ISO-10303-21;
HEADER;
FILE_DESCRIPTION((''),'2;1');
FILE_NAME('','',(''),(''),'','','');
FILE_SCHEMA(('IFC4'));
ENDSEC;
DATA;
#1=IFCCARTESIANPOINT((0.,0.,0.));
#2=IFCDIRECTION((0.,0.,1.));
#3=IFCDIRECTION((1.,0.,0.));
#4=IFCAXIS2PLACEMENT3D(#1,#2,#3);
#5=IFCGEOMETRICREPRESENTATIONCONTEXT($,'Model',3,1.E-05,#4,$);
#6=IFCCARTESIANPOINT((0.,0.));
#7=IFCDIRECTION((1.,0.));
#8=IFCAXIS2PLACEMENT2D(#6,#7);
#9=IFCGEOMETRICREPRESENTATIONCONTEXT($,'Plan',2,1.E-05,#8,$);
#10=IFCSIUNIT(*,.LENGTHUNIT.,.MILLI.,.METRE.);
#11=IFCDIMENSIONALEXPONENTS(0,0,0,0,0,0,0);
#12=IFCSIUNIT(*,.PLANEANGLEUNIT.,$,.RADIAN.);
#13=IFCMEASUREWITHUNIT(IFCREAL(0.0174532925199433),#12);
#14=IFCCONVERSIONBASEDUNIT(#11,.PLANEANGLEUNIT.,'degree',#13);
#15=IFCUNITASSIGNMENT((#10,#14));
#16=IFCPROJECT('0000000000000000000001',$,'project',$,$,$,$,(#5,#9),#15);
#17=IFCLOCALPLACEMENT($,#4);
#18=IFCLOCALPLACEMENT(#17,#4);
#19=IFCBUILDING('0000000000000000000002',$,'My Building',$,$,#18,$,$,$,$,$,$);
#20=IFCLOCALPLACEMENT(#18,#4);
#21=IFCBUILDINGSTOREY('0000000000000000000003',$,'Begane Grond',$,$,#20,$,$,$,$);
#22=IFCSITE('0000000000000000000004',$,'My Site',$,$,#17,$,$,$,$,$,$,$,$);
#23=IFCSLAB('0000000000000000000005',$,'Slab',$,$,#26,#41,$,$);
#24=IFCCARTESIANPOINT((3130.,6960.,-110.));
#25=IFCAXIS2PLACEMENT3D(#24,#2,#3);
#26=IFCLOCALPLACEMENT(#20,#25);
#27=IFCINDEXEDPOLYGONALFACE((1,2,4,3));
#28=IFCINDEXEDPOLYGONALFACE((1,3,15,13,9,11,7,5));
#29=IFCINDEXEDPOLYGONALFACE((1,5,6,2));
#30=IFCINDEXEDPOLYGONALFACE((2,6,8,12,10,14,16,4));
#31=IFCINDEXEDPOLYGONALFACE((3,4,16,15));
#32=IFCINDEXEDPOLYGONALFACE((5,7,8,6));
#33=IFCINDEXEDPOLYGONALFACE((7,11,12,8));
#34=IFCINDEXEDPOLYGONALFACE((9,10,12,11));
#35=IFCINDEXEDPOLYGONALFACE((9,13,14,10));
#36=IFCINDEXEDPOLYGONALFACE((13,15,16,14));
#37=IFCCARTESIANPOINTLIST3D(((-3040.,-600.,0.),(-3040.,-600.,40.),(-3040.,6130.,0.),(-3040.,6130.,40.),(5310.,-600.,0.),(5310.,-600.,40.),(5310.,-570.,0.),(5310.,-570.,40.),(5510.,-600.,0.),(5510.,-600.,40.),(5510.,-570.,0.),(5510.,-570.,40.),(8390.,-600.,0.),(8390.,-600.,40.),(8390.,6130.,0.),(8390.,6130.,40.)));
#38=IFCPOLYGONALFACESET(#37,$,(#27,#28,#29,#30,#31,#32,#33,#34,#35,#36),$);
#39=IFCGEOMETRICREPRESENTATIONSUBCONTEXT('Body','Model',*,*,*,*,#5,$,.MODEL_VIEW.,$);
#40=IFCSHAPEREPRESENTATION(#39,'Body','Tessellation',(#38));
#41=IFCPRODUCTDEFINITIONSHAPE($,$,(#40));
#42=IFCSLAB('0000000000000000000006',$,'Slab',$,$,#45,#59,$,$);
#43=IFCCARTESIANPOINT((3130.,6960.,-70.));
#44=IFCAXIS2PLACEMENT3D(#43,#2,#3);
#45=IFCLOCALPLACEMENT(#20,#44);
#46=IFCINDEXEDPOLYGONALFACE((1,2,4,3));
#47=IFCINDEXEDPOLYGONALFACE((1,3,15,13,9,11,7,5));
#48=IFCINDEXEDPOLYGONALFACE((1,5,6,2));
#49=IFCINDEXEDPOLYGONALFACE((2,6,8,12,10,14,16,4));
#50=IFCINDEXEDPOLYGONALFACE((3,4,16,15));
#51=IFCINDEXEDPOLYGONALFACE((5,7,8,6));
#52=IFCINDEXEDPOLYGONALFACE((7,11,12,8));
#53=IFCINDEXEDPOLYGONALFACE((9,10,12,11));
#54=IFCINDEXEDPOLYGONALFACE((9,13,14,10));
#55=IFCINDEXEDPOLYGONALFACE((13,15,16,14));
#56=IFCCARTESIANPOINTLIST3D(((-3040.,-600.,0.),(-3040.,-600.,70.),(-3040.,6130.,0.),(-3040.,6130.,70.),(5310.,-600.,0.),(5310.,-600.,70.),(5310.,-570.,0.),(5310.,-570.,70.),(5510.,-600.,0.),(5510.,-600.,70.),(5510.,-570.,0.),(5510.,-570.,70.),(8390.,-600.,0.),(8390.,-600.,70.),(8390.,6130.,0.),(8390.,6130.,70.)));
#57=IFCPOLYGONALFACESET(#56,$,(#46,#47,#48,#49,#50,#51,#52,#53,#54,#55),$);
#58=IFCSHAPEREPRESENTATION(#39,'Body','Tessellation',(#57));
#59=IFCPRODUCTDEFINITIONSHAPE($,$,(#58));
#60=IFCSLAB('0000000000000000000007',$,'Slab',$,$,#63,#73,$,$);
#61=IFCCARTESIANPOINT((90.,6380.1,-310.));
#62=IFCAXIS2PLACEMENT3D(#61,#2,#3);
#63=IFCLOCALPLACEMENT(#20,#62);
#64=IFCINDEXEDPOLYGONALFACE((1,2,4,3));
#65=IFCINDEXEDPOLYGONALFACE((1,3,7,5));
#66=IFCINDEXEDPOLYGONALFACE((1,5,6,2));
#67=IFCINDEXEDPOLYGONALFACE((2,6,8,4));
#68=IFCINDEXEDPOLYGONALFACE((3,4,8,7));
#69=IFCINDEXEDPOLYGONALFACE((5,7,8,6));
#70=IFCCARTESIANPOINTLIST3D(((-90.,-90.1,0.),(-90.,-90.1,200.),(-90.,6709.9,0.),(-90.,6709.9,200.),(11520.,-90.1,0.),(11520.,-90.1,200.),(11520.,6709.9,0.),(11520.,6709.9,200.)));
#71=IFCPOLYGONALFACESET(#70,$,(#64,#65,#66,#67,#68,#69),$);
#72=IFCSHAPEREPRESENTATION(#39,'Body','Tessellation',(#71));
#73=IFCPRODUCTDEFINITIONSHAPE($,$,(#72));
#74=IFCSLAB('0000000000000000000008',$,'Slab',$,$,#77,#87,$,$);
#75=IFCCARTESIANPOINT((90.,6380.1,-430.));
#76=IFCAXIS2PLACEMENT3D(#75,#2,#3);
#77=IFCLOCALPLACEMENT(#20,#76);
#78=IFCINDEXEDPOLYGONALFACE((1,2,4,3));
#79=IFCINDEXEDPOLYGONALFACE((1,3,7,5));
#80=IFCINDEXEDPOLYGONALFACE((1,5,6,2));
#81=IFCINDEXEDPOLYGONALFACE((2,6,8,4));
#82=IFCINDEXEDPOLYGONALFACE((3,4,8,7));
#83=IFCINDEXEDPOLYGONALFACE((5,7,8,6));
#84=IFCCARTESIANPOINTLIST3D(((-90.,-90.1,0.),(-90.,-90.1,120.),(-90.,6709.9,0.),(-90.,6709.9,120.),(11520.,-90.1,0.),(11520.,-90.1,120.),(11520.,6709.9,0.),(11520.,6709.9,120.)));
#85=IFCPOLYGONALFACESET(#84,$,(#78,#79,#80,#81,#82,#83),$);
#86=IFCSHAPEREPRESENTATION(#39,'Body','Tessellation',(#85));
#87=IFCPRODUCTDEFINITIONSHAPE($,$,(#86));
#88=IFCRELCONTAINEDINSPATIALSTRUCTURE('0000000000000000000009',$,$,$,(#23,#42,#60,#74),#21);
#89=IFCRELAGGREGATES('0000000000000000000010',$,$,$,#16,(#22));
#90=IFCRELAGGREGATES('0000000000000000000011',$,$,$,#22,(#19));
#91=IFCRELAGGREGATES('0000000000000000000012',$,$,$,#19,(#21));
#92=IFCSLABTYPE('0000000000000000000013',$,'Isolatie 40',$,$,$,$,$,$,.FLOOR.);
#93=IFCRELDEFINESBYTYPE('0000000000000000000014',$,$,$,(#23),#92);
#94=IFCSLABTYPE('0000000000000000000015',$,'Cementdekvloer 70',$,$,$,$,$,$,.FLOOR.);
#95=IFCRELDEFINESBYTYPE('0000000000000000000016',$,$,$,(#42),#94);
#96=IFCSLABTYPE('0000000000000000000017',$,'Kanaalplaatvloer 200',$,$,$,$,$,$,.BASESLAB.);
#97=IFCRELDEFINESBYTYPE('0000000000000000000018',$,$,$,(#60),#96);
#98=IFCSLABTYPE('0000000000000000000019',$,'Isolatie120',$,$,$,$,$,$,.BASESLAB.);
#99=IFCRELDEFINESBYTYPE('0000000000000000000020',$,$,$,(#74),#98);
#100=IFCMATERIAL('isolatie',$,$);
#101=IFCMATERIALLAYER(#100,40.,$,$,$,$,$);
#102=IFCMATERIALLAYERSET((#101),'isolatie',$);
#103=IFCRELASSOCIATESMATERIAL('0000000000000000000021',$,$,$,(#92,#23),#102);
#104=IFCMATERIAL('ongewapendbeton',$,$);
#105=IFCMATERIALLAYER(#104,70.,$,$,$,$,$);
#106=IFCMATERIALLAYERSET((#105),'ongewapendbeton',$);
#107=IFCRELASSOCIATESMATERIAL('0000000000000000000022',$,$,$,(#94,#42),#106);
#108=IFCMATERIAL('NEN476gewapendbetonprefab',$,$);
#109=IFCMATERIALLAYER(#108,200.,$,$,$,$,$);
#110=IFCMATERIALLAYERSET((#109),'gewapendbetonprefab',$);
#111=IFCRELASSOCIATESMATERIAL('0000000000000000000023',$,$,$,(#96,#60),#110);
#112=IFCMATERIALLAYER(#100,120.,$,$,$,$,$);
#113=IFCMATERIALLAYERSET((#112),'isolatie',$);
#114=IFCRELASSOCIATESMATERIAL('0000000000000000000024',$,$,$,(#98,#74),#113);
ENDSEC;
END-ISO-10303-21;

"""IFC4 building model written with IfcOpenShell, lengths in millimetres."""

from ifc_helpers import new_model, entity, si_unit, converted_unit, frame, origin_with_axes, origin_2d_with_axis, place, context, subcontext, project, spatial, line, indexed_curve, outline, extrude, material, layer, layer_set, layer_usage, type_object, element, save


model = new_model("IFC4")

# Units and contexts
model_context = context("Model", 3, precision=1e-05, world=origin_with_axes())
plan_context = context("Plan", 2, precision=1e-05, world=origin_2d_with_axis())
body_context = subcontext(model_context, "Body", "Model", "MODEL_VIEW")
ifc_project = project(units=[si_unit("LENGTHUNIT", "METRE", prefix="MILLI"), converted_unit("PLANEANGLEUNIT", "degree", entity("IfcReal", 0.0174532925199433), si_unit("PLANEANGLEUNIT", "RADIAN"), dimensions=[0, 0, 0, 0, 0, 0, 0])], contexts=[model_context, plan_context])

# Site, building, storey
site_placement = place(None, origin_with_axes())
site = spatial("IfcSite", under=ifc_project, at=site_placement, Name="My Site")
building_placement = place(site_placement, origin_with_axes())
building = spatial("IfcBuilding", under=site, at=building_placement, Name="My Building")
storey_placement = place(building_placement, origin_with_axes())
storey = spatial("IfcBuildingStorey", under=building, at=storey_placement, Name="Begane Grond")

# Shared definitions
ifc_material_1 = material(Name="NEN476gewapendbetonprefab")

# Slabs
ifc_material_2 = material(Name="isolatie")
ifc_layer_1 = layer(ifc_material_2, 40.0)
ifc_layer_set_1 = layer_set([ifc_layer_1], Name="isolatie")
ifc_layer_usage_1 = layer_usage(ifc_layer_set_1, "AXIS3", "POSITIVE", 0.0)
slab_type_1 = type_object("IfcSlabType", Name="Isolatie 40", PredefinedType="FLOOR", material=ifc_layer_set_1)
slab_1_placement = place(storey_placement, frame((3130.0, 6960.0, -110.0), z_axis=(0.0, 0.0, 1.0), x_axis=(1.0, 0.0, 0.0)))
element("IfcSlab", 1, at=slab_1_placement, inside=storey, type_object=slab_type_1, material=ifc_layer_usage_1, Name="Slab", context=body_context, shape_type="SweptSolid", body=[
    extrude(outline(indexed_curve([(5510.0, -600.0), (8390.0, -600.0), (5510.0, -570.0), (8390.0, 6130.0), (5310.0, -570.0), (5310.0, -600.0), (-3040.0, -600.0), (-3040.0, 6130.0)], segments=[line(5, 3), line(3, 1), line(1, 2), line(2, 4), line(4, 8), line(8, 7), line(7, 6), line(6, 5)], self_intersect=False)), None, (0.0, 0.0, 1.0), 40.0),
])
ifc_material_3 = material(Name="ongewapendbeton")
ifc_layer_2 = layer(ifc_material_3, 70.0)
ifc_layer_set_2 = layer_set([ifc_layer_2], Name="ongewapendbeton")
ifc_layer_usage_2 = layer_usage(ifc_layer_set_2, "AXIS3", "POSITIVE", 0.0)
slab_type_2 = type_object("IfcSlabType", Name="Cementdekvloer 70", PredefinedType="FLOOR", material=ifc_layer_set_2)
slab_2_placement = place(storey_placement, frame((3130.0, 6960.0, -70.0), z_axis=(0.0, 0.0, 1.0), x_axis=(1.0, 0.0, 0.0)))
element("IfcSlab", 2, at=slab_2_placement, inside=storey, type_object=slab_type_2, material=ifc_layer_usage_2, Name="Slab", context=body_context, shape_type="SweptSolid", body=[
    extrude(outline(indexed_curve([(-3040.0, -600.0), (5310.0, -600.0), (5310.0, -570.0), (5510.0, -570.0), (5510.0, -600.0), (8390.0, -600.0), (8390.0, 6130.0), (-3040.0, 6130.0)], segments=[line(1, 8), line(8, 7), line(7, 6), line(6, 5), line(5, 4), line(4, 3), line(3, 2), line(2, 1)], self_intersect=False)), None, (0.0, 0.0, 1.0), 70.0),
])
ifc_layer_3 = layer(ifc_material_1, 200.0)
ifc_layer_set_3 = layer_set([ifc_layer_3], Name="gewapendbetonprefab")
ifc_layer_usage_3 = layer_usage(ifc_layer_set_3, "AXIS3", "POSITIVE", 0.0)
slab_type_3 = type_object("IfcSlabType", Name="Kanaalplaatvloer 200", PredefinedType="BASESLAB", material=ifc_layer_set_3)
slab_3_placement = place(storey_placement, frame((90.0, 6380.1, -310.0), z_axis=(0.0, 0.0, 1.0), x_axis=(1.0, 0.0, 0.0)))
element("IfcSlab", 3, at=slab_3_placement, inside=storey, type_object=slab_type_3, material=ifc_layer_usage_3, Name="Slab", context=body_context, shape_type="SweptSolid", body=[
    extrude(outline(indexed_curve([(-90.0, 6709.9), (-90.0, -90.1), (11520.0, -90.1), (11520.0, 6709.9)], segments=[line(4, 1), line(1, 2), line(2, 3), line(3, 4)], self_intersect=False)), None, (0.0, 0.0, 1.0), 200.0),
])
ifc_layer_4 = layer(ifc_material_2, 120.0)
ifc_layer_set_4 = layer_set([ifc_layer_4], Name="isolatie")
ifc_layer_usage_4 = layer_usage(ifc_layer_set_4, "AXIS3", "POSITIVE", 0.0)
slab_type_4 = type_object("IfcSlabType", Name="Isolatie120", PredefinedType="BASESLAB", material=ifc_layer_set_4)
slab_4_placement = place(storey_placement, frame((90.0, 6380.1, -430.0), z_axis=(0.0, 0.0, 1.0), x_axis=(1.0, 0.0, 0.0)))
element("IfcSlab", 4, at=slab_4_placement, inside=storey, type_object=slab_type_4, material=ifc_layer_usage_4, Name="Slab", context=body_context, shape_type="SweptSolid", body=[
    extrude(outline(indexed_curve([(-90.0, 6709.9), (-90.0, -90.1), (11520.0, -90.1), (11520.0, 6709.9)], segments=[line(4, 1), line(1, 2), line(2, 3), line(3, 4)], self_intersect=False)), None, (0.0, 0.0, 1.0), 120.0),
])

save(model, "model.ifc")
